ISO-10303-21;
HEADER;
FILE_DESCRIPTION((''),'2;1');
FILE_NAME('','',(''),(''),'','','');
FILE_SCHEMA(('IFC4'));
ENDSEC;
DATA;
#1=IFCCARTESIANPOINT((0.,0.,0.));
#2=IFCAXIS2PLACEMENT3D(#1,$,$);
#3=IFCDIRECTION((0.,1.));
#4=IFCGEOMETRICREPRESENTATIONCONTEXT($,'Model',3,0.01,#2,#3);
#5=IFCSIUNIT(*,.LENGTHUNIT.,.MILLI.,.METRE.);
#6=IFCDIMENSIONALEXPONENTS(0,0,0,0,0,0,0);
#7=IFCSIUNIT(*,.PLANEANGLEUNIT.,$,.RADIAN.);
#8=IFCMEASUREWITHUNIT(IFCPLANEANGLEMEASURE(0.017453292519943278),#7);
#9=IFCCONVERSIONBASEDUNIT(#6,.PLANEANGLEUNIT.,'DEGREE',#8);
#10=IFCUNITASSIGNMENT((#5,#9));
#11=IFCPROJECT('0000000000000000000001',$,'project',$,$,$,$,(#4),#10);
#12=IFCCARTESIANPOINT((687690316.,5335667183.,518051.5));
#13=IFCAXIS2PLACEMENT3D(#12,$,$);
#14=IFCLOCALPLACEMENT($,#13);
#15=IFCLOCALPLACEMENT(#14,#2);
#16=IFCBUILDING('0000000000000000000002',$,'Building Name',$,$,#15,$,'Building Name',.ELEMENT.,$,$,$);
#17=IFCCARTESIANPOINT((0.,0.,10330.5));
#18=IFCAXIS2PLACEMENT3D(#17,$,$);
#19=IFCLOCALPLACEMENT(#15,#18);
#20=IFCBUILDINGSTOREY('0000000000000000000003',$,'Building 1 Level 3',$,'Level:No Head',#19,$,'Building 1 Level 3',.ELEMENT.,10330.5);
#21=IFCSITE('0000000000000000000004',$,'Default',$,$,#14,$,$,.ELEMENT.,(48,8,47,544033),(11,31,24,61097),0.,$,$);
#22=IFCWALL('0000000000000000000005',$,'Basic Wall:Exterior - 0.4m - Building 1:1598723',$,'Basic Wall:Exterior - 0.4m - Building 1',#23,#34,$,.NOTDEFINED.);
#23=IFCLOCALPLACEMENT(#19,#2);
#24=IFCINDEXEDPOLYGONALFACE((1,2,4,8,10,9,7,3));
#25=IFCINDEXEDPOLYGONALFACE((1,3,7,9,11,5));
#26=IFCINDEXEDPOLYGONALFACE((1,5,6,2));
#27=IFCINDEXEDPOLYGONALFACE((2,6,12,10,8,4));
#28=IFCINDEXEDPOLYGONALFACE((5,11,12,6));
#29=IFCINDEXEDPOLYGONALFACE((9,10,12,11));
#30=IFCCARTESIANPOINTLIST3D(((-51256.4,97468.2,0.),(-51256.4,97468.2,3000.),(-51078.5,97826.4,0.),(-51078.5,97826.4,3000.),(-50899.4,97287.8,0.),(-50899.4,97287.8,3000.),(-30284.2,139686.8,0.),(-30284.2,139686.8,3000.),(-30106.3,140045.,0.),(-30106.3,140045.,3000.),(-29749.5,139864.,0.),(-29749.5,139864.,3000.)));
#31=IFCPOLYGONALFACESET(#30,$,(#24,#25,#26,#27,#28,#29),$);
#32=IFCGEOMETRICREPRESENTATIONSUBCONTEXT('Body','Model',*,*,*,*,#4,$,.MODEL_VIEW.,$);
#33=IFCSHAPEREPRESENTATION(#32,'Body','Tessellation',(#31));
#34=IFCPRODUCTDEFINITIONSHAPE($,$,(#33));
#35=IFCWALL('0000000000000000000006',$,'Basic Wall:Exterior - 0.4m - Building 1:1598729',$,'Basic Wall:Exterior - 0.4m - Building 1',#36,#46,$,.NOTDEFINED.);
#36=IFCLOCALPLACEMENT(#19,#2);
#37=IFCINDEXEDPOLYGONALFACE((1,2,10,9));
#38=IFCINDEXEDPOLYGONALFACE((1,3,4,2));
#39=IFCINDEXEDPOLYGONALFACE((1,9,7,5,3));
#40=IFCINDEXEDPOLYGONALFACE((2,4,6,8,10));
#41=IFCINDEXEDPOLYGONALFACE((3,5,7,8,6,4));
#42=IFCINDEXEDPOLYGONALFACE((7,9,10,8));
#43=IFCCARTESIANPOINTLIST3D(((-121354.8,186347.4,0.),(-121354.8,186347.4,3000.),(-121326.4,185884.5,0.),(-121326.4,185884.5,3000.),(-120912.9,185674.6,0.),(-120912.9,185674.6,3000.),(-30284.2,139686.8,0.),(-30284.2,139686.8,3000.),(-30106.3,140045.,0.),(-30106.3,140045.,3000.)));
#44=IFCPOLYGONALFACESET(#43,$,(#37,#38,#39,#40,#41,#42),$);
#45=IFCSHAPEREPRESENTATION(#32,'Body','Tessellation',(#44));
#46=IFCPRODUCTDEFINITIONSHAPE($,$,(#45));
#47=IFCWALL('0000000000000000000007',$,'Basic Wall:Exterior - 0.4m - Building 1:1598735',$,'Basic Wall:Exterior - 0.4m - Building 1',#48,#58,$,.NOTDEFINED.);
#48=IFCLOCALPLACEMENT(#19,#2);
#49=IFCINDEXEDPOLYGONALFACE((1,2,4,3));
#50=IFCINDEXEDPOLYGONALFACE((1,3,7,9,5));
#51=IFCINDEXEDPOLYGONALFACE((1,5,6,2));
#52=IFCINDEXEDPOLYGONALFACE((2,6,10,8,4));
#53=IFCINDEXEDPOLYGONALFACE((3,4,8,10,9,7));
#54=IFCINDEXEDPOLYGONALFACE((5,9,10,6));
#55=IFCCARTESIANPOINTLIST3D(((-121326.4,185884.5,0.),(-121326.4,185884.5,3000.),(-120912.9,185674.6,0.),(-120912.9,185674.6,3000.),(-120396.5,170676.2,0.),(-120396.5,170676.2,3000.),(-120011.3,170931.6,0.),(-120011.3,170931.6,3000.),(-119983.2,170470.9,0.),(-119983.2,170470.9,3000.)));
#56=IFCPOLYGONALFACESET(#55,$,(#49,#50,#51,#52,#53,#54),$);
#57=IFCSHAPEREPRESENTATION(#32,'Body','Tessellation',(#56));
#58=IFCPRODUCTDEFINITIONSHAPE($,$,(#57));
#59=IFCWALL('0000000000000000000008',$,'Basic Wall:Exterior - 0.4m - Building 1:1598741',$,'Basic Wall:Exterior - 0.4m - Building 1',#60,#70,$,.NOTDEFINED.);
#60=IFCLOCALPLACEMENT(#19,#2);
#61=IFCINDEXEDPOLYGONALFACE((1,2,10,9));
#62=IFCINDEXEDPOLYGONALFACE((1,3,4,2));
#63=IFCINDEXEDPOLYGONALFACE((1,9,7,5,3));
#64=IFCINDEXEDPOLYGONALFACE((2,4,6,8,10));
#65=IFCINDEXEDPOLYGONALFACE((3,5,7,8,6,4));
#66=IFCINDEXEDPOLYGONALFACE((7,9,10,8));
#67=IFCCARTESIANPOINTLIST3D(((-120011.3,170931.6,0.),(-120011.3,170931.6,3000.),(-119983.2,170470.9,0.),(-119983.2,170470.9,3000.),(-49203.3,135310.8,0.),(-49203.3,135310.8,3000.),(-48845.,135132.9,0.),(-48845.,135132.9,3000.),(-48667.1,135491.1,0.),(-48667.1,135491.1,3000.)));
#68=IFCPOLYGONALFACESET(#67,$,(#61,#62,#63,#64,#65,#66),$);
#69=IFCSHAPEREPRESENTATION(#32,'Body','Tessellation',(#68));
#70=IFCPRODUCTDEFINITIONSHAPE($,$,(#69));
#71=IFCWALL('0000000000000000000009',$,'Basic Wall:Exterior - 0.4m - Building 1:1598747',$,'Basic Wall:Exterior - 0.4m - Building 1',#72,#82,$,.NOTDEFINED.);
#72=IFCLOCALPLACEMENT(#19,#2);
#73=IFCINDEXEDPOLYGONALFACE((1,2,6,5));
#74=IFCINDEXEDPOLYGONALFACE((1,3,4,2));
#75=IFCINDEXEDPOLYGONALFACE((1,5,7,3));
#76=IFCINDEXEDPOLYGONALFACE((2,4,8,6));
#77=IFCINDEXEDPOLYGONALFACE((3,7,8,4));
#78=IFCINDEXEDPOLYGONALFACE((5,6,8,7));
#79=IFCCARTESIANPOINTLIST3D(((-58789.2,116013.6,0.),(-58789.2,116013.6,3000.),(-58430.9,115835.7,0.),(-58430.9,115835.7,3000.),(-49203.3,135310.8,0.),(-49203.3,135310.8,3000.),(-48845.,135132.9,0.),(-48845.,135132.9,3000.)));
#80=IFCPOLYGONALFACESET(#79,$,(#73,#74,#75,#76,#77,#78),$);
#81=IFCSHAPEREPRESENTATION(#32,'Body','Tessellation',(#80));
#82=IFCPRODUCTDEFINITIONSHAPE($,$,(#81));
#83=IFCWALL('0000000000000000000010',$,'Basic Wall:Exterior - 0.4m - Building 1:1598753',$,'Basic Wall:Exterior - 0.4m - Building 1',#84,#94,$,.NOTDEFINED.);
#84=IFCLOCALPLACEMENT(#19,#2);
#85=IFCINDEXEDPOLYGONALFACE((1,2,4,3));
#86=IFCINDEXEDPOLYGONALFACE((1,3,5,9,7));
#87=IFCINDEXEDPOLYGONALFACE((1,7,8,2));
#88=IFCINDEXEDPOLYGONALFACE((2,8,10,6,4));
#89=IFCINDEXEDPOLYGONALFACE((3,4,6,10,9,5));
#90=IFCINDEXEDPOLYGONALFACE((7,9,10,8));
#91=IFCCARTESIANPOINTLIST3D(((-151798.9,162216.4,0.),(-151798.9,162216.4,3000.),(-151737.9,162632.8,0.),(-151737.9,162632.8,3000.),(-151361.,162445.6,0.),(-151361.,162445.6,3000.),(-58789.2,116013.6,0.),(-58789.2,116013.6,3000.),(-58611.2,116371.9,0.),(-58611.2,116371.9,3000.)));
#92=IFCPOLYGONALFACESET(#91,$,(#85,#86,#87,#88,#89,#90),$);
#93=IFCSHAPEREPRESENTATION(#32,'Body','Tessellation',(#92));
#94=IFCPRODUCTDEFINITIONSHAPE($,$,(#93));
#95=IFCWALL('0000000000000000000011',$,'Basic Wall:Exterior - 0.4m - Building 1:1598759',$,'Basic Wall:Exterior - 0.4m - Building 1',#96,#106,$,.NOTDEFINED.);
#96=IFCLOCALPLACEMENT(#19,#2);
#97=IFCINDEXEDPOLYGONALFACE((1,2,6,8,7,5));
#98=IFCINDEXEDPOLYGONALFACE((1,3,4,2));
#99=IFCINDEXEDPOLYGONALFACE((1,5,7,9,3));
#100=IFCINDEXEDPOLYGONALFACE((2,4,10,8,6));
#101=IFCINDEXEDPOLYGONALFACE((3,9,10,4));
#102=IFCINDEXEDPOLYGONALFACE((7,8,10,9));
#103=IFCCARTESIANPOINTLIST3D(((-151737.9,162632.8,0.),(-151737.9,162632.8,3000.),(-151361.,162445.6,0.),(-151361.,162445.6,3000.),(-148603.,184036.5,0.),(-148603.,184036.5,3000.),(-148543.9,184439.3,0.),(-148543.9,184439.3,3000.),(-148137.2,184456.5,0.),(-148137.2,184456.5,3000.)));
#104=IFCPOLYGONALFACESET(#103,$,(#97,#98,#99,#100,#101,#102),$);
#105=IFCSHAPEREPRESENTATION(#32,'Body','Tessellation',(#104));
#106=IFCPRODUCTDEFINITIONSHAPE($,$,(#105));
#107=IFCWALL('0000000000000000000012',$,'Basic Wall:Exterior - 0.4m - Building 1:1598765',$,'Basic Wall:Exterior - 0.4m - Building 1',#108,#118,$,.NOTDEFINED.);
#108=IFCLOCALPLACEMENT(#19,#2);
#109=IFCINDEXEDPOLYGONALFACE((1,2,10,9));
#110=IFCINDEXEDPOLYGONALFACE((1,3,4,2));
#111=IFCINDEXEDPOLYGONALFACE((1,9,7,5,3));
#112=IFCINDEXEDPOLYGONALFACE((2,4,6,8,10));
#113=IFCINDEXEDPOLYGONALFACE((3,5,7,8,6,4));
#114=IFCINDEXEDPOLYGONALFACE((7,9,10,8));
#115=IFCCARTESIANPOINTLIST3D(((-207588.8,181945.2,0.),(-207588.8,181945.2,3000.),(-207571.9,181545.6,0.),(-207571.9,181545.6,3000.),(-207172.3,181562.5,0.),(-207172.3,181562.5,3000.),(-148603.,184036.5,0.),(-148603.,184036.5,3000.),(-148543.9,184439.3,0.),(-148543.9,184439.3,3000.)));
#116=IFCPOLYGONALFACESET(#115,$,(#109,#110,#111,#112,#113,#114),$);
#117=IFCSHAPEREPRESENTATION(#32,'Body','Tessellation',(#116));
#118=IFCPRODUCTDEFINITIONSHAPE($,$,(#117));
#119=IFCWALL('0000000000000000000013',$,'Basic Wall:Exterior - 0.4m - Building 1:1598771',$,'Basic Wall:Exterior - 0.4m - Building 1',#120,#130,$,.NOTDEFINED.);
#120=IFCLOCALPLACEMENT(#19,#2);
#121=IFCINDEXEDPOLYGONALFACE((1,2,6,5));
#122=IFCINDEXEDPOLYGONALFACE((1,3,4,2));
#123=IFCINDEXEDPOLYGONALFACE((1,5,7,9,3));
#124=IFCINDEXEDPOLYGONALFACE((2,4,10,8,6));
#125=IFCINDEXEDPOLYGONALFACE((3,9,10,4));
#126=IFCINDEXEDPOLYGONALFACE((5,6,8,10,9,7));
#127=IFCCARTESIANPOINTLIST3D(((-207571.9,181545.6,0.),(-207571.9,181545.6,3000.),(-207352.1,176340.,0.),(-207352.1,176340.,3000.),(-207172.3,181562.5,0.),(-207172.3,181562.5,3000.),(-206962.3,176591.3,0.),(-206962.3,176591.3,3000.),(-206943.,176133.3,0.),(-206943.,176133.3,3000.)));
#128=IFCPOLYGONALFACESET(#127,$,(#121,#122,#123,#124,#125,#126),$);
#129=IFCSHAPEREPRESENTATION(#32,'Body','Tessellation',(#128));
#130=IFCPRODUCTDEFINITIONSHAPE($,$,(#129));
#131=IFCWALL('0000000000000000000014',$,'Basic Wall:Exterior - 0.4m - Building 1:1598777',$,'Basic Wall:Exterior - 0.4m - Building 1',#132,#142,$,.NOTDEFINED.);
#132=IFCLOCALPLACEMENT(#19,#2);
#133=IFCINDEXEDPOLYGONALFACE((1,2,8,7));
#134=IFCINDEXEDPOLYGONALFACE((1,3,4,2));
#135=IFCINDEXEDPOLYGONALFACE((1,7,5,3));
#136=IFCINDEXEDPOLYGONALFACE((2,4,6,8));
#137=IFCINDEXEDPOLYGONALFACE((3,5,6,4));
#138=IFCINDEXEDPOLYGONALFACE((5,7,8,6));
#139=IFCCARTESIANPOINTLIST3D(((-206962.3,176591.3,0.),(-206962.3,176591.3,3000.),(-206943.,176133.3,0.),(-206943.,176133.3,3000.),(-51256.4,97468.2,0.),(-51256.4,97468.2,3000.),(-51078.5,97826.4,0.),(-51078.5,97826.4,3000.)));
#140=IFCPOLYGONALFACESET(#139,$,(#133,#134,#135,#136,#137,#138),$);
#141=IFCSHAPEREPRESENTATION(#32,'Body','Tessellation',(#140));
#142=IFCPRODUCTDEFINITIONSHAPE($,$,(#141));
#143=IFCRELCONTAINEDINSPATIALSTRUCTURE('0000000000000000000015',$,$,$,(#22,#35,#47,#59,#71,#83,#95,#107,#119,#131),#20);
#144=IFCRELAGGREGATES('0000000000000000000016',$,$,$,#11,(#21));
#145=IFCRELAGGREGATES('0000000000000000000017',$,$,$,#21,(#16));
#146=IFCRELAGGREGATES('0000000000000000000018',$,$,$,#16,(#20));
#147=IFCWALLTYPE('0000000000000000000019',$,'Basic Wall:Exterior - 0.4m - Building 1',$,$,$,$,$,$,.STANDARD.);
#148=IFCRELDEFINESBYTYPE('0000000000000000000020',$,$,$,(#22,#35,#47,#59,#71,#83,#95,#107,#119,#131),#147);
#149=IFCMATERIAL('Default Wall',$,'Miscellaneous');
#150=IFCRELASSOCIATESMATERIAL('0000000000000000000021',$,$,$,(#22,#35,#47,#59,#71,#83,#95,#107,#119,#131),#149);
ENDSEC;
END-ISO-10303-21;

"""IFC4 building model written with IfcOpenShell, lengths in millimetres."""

from ifc_helpers import new_model, entity, si_unit, converted_unit, direction, frame, origin, place, context, subcontext, project, spatial, indexed_curve, outline, extrude, material, type_object, element, save


model = new_model("IFC4")

# Units and contexts
model_context = context("Model", 3, precision=0.01, world=origin(), true_north=direction((0.0, 1.0)))
body_context = subcontext(model_context, "Body", "Model", "MODEL_VIEW")
ifc_project = project(units=[si_unit("LENGTHUNIT", "METRE", prefix="MILLI"), converted_unit("PLANEANGLEUNIT", "DEGREE", entity("IfcPlaneAngleMeasure", 0.017453292519943278), si_unit("PLANEANGLEUNIT", "RADIAN"), dimensions=[0, 0, 0, 0, 0, 0, 0])], contexts=[model_context])

# Site, building, storey
site_placement = place(None, frame((687690316.0, 5335667183.0, 518051.5)))
site = spatial("IfcSite", under=ifc_project, at=site_placement, Name="Default", CompositionType="ELEMENT", RefLatitude=(48, 8, 47, 544033), RefLongitude=(11, 31, 24, 61097), RefElevation=0.0)
building_placement = place(site_placement, origin())
building = spatial("IfcBuilding", under=site, at=building_placement, Name="Building Name", LongName="Building Name", CompositionType="ELEMENT")
storey_placement = place(building_placement, frame((0.0, 0.0, 10330.5)))
storey = spatial("IfcBuildingStorey", under=building, at=storey_placement, Name="Building 1 Level 3", ObjectType="Level:No Head", LongName="Building 1 Level 3", CompositionType="ELEMENT", Elevation=10330.5)

# Walls
ifc_material_1 = material(Name="Default Wall", Category="Miscellaneous")
wall_type = type_object("IfcWallType", Name="Basic Wall:Exterior - 0.4m - Building 1", PredefinedType="STANDARD")
wall_1_placement = place(storey_placement, frame((-51078.5, 97376.7, 0.0), z_axis=(0.0, 0.0, 1.0), x_axis=(0.444885, 0.895588, 0.0)))
element("IfcWall", 1, at=wall_1_placement, inside=storey, type_object=wall_type, material=ifc_material_1, Name="Basic Wall:Exterior - 0.4m - Building 1:1598723", ObjectType="Basic Wall:Exterior - 0.4m - Building 1", PredefinedType="NOTDEFINED", context=body_context, shape_type="SweptSolid", body=[
    extrude(outline(indexed_curve([(47540.0, -200.0), (47543.5, 200.0), (47143.4, 200.0), (402.7, 200.0), (2.7, 200.0), (0.0, -200.0), (47540.0, -200.0)], self_intersect=False)), origin(), (0.0, 0.0, 1.0), 3000.0),
])
wall_2_placement = place(storey_placement, frame((-30193.7, 139865.1, 0.0), z_axis=(0.0, 0.0, 1.0), x_axis=(-0.891761, 0.452507, 0.0)))
element("IfcWall", 2, at=wall_2_placement, inside=storey, type_object=wall_type, material=ifc_material_1, Name="Basic Wall:Exterior - 0.4m - Building 1:1598729", ObjectType="Basic Wall:Exterior - 0.4m - Building 1", PredefinedType="NOTDEFINED", context=body_context, shape_type="SweptSolid", body=[
    extrude(outline(indexed_curve([(102327.4, -200.0), (102092.7, 200.0), (101628.9, 200.0), (0.0, 200.0), (3.4, -200.0), (102327.4, -200.0)], self_intersect=False)), origin(), (0.0, 0.0, 1.0), 3000.0),
])
wall_3_placement = place(storey_placement, frame((-121126.8, 185896.7, 0.0), z_axis=(0.0, 0.0, 1.0), x_axis=(0.061037, -0.998136, 0.0)))
element("IfcWall", 3, at=wall_3_placement, inside=storey, type_object=wall_type, material=ifc_material_1, Name="Basic Wall:Exterior - 0.4m - Building 1:1598735", ObjectType="Basic Wall:Exterior - 0.4m - Building 1", PredefinedType="NOTDEFINED", context=body_context, shape_type="SweptSolid", body=[
    extrude(outline(indexed_curve([(15236.7, -200.0), (15466.8, 200.0), (15005.3, 200.0), (234.7, 200.0), (0.0, -200.0), (15236.7, -200.0)], self_intersect=False)), origin(), (0.0, 0.0, 1.0), 3000.0),
])
wall_4_placement = place(storey_placement, frame((-120100.3, 170752.4, 0.0), z_axis=(0.0, 0.0, 1.0), x_axis=(0.895588, -0.444885, 0.0)))
element("IfcWall", 4, at=wall_4_placement, inside=storey, type_object=wall_type, material=ifc_material_1, Name="Basic Wall:Exterior - 0.4m - Building 1:1598741", ObjectType="Basic Wall:Exterior - 0.4m - Building 1", PredefinedType="NOTDEFINED", context=body_context, shape_type="SweptSolid", body=[
    extrude(outline(indexed_curve([(79662.0, -200.0), (79662.0, 200.0), (0.0, 200.0), (230.2, -200.0), (79262.0, -200.0), (79662.0, -200.0)], self_intersect=False)), origin(), (0.0, 0.0, 1.0), 3000.0),
])
wall_5_placement = place(storey_placement, frame((-49024.1, 135221.9, 0.0), z_axis=(0.0, 0.0, 1.0), x_axis=(-0.444885, -0.895588, 0.0)))
element("IfcWall", 5, at=wall_5_placement, inside=storey, type_object=wall_type, material=ifc_material_1, Name="Basic Wall:Exterior - 0.4m - Building 1:1598747", ObjectType="Basic Wall:Exterior - 0.4m - Building 1", PredefinedType="NOTDEFINED", context=body_context, shape_type="SweptSolid", body=[
    extrude(outline(indexed_curve([(21547.0, 200.0), (0.0, 200.0), (0.0, -200.0), (21547.0, -200.0), (21547.0, 200.0)], self_intersect=False)), origin(), (0.0, 0.0, 1.0), 3000.0),
])
wall_6_placement = place(storey_placement, frame((-58700.2, 116192.8, 0.0), z_axis=(0.0, 0.0, 1.0), x_axis=(-0.895588, 0.444885, 0.0)))
element("IfcWall", 6, at=wall_6_placement, inside=storey, type_object=wall_type, material=ifc_material_1, Name="Basic Wall:Exterior - 0.4m - Building 1:1598753", ObjectType="Basic Wall:Exterior - 0.4m - Building 1", PredefinedType="NOTDEFINED", context=body_context, shape_type="SweptSolid", body=[
    extrude(outline(indexed_curve([(103983.9, -200.0), (103853.3, 200.0), (0.0, 200.0), (0.0, -200.0), (103563.1, -200.0), (103983.9, -200.0)], self_intersect=False)), origin(), (0.0, 0.0, 1.0), 3000.0),
])
wall_7_placement = place(storey_placement, frame((-151558.9, 162474.6, 0.0), z_axis=(0.0, 0.0, 1.0), x_axis=(0.144921, 0.989443, 0.0)))
element("IfcWall", 7, at=wall_7_placement, inside=storey, type_object=wall_type, material=ifc_material_1, Name="Basic Wall:Exterior - 0.4m - Building 1:1598759", ObjectType="Basic Wall:Exterior - 0.4m - Building 1", PredefinedType="NOTDEFINED", context=body_context, shape_type="SweptSolid", body=[
    extrude(outline(indexed_curve([(22245.8, -200.0), (22169.8, 200.0), (21762.7, 200.0), (130.6, 200.0), (0.0, -200.0), (22245.8, -200.0)], self_intersect=False)), origin(), (0.0, 0.0, 1.0), 3000.0),
])
wall_8_placement = place(storey_placement, frame((-148535.5, 184239.5, 0.0), z_axis=(0.0, 0.0, 1.0), x_axis=(-0.999109, -0.042203, 0.0)))
element("IfcWall", 8, at=wall_8_placement, inside=storey, type_object=wall_type, material=ifc_material_1, Name="Basic Wall:Exterior - 0.4m - Building 1:1598765", ObjectType="Basic Wall:Exterior - 0.4m - Building 1", PredefinedType="NOTDEFINED", context=body_context, shape_type="SweptSolid", body=[
    extrude(outline(indexed_curve([(59097.5, -200.0), (59097.5, 200.0), (58697.5, 200.0), (76.0, 200.0), (0.0, -200.0), (59097.5, -200.0)], self_intersect=False)), origin(), (0.0, 0.0, 1.0), 3000.0),
])
wall_9_placement = place(storey_placement, frame((-207372.1, 181554.0, 0.0), z_axis=(0.0, 0.0, 1.0), x_axis=(0.042203, -0.999109, 0.0)))
element("IfcWall", 9, at=wall_9_placement, inside=storey, type_object=wall_type, material=ifc_material_1, Name="Basic Wall:Exterior - 0.4m - Building 1:1598771", ObjectType="Basic Wall:Exterior - 0.4m - Building 1", PredefinedType="NOTDEFINED", context=body_context, shape_type="SweptSolid", body=[
    extrude(outline(indexed_curve([(5210.2, -200.0), (5434.0, 200.0), (4975.6, 200.0), (0.0, 200.0), (0.0, -200.0), (5210.2, -200.0)], self_intersect=False)), origin(), (0.0, 0.0, 1.0), 3000.0),
])
wall_10_placement = place(storey_placement, frame((-207052.5, 176412.8, 0.0), z_axis=(0.0, 0.0, 1.0), x_axis=(0.892534, -0.450979, 0.0)))
element("IfcWall", 10, at=wall_10_placement, inside=storey, type_object=wall_type, material=ifc_material_1, Name="Basic Wall:Exterior - 0.4m - Building 1:1598777", ObjectType="Basic Wall:Exterior - 0.4m - Building 1", PredefinedType="NOTDEFINED", context=body_context, shape_type="SweptSolid", body=[
    extrude(outline(indexed_curve([(174655.7, -200.0), (174653.0, 200.0), (0.0, 200.0), (223.8, -200.0), (174655.7, -200.0)], self_intersect=False)), origin(), (0.0, 0.0, 1.0), 3000.0),
])

save(model, "model.ifc")
